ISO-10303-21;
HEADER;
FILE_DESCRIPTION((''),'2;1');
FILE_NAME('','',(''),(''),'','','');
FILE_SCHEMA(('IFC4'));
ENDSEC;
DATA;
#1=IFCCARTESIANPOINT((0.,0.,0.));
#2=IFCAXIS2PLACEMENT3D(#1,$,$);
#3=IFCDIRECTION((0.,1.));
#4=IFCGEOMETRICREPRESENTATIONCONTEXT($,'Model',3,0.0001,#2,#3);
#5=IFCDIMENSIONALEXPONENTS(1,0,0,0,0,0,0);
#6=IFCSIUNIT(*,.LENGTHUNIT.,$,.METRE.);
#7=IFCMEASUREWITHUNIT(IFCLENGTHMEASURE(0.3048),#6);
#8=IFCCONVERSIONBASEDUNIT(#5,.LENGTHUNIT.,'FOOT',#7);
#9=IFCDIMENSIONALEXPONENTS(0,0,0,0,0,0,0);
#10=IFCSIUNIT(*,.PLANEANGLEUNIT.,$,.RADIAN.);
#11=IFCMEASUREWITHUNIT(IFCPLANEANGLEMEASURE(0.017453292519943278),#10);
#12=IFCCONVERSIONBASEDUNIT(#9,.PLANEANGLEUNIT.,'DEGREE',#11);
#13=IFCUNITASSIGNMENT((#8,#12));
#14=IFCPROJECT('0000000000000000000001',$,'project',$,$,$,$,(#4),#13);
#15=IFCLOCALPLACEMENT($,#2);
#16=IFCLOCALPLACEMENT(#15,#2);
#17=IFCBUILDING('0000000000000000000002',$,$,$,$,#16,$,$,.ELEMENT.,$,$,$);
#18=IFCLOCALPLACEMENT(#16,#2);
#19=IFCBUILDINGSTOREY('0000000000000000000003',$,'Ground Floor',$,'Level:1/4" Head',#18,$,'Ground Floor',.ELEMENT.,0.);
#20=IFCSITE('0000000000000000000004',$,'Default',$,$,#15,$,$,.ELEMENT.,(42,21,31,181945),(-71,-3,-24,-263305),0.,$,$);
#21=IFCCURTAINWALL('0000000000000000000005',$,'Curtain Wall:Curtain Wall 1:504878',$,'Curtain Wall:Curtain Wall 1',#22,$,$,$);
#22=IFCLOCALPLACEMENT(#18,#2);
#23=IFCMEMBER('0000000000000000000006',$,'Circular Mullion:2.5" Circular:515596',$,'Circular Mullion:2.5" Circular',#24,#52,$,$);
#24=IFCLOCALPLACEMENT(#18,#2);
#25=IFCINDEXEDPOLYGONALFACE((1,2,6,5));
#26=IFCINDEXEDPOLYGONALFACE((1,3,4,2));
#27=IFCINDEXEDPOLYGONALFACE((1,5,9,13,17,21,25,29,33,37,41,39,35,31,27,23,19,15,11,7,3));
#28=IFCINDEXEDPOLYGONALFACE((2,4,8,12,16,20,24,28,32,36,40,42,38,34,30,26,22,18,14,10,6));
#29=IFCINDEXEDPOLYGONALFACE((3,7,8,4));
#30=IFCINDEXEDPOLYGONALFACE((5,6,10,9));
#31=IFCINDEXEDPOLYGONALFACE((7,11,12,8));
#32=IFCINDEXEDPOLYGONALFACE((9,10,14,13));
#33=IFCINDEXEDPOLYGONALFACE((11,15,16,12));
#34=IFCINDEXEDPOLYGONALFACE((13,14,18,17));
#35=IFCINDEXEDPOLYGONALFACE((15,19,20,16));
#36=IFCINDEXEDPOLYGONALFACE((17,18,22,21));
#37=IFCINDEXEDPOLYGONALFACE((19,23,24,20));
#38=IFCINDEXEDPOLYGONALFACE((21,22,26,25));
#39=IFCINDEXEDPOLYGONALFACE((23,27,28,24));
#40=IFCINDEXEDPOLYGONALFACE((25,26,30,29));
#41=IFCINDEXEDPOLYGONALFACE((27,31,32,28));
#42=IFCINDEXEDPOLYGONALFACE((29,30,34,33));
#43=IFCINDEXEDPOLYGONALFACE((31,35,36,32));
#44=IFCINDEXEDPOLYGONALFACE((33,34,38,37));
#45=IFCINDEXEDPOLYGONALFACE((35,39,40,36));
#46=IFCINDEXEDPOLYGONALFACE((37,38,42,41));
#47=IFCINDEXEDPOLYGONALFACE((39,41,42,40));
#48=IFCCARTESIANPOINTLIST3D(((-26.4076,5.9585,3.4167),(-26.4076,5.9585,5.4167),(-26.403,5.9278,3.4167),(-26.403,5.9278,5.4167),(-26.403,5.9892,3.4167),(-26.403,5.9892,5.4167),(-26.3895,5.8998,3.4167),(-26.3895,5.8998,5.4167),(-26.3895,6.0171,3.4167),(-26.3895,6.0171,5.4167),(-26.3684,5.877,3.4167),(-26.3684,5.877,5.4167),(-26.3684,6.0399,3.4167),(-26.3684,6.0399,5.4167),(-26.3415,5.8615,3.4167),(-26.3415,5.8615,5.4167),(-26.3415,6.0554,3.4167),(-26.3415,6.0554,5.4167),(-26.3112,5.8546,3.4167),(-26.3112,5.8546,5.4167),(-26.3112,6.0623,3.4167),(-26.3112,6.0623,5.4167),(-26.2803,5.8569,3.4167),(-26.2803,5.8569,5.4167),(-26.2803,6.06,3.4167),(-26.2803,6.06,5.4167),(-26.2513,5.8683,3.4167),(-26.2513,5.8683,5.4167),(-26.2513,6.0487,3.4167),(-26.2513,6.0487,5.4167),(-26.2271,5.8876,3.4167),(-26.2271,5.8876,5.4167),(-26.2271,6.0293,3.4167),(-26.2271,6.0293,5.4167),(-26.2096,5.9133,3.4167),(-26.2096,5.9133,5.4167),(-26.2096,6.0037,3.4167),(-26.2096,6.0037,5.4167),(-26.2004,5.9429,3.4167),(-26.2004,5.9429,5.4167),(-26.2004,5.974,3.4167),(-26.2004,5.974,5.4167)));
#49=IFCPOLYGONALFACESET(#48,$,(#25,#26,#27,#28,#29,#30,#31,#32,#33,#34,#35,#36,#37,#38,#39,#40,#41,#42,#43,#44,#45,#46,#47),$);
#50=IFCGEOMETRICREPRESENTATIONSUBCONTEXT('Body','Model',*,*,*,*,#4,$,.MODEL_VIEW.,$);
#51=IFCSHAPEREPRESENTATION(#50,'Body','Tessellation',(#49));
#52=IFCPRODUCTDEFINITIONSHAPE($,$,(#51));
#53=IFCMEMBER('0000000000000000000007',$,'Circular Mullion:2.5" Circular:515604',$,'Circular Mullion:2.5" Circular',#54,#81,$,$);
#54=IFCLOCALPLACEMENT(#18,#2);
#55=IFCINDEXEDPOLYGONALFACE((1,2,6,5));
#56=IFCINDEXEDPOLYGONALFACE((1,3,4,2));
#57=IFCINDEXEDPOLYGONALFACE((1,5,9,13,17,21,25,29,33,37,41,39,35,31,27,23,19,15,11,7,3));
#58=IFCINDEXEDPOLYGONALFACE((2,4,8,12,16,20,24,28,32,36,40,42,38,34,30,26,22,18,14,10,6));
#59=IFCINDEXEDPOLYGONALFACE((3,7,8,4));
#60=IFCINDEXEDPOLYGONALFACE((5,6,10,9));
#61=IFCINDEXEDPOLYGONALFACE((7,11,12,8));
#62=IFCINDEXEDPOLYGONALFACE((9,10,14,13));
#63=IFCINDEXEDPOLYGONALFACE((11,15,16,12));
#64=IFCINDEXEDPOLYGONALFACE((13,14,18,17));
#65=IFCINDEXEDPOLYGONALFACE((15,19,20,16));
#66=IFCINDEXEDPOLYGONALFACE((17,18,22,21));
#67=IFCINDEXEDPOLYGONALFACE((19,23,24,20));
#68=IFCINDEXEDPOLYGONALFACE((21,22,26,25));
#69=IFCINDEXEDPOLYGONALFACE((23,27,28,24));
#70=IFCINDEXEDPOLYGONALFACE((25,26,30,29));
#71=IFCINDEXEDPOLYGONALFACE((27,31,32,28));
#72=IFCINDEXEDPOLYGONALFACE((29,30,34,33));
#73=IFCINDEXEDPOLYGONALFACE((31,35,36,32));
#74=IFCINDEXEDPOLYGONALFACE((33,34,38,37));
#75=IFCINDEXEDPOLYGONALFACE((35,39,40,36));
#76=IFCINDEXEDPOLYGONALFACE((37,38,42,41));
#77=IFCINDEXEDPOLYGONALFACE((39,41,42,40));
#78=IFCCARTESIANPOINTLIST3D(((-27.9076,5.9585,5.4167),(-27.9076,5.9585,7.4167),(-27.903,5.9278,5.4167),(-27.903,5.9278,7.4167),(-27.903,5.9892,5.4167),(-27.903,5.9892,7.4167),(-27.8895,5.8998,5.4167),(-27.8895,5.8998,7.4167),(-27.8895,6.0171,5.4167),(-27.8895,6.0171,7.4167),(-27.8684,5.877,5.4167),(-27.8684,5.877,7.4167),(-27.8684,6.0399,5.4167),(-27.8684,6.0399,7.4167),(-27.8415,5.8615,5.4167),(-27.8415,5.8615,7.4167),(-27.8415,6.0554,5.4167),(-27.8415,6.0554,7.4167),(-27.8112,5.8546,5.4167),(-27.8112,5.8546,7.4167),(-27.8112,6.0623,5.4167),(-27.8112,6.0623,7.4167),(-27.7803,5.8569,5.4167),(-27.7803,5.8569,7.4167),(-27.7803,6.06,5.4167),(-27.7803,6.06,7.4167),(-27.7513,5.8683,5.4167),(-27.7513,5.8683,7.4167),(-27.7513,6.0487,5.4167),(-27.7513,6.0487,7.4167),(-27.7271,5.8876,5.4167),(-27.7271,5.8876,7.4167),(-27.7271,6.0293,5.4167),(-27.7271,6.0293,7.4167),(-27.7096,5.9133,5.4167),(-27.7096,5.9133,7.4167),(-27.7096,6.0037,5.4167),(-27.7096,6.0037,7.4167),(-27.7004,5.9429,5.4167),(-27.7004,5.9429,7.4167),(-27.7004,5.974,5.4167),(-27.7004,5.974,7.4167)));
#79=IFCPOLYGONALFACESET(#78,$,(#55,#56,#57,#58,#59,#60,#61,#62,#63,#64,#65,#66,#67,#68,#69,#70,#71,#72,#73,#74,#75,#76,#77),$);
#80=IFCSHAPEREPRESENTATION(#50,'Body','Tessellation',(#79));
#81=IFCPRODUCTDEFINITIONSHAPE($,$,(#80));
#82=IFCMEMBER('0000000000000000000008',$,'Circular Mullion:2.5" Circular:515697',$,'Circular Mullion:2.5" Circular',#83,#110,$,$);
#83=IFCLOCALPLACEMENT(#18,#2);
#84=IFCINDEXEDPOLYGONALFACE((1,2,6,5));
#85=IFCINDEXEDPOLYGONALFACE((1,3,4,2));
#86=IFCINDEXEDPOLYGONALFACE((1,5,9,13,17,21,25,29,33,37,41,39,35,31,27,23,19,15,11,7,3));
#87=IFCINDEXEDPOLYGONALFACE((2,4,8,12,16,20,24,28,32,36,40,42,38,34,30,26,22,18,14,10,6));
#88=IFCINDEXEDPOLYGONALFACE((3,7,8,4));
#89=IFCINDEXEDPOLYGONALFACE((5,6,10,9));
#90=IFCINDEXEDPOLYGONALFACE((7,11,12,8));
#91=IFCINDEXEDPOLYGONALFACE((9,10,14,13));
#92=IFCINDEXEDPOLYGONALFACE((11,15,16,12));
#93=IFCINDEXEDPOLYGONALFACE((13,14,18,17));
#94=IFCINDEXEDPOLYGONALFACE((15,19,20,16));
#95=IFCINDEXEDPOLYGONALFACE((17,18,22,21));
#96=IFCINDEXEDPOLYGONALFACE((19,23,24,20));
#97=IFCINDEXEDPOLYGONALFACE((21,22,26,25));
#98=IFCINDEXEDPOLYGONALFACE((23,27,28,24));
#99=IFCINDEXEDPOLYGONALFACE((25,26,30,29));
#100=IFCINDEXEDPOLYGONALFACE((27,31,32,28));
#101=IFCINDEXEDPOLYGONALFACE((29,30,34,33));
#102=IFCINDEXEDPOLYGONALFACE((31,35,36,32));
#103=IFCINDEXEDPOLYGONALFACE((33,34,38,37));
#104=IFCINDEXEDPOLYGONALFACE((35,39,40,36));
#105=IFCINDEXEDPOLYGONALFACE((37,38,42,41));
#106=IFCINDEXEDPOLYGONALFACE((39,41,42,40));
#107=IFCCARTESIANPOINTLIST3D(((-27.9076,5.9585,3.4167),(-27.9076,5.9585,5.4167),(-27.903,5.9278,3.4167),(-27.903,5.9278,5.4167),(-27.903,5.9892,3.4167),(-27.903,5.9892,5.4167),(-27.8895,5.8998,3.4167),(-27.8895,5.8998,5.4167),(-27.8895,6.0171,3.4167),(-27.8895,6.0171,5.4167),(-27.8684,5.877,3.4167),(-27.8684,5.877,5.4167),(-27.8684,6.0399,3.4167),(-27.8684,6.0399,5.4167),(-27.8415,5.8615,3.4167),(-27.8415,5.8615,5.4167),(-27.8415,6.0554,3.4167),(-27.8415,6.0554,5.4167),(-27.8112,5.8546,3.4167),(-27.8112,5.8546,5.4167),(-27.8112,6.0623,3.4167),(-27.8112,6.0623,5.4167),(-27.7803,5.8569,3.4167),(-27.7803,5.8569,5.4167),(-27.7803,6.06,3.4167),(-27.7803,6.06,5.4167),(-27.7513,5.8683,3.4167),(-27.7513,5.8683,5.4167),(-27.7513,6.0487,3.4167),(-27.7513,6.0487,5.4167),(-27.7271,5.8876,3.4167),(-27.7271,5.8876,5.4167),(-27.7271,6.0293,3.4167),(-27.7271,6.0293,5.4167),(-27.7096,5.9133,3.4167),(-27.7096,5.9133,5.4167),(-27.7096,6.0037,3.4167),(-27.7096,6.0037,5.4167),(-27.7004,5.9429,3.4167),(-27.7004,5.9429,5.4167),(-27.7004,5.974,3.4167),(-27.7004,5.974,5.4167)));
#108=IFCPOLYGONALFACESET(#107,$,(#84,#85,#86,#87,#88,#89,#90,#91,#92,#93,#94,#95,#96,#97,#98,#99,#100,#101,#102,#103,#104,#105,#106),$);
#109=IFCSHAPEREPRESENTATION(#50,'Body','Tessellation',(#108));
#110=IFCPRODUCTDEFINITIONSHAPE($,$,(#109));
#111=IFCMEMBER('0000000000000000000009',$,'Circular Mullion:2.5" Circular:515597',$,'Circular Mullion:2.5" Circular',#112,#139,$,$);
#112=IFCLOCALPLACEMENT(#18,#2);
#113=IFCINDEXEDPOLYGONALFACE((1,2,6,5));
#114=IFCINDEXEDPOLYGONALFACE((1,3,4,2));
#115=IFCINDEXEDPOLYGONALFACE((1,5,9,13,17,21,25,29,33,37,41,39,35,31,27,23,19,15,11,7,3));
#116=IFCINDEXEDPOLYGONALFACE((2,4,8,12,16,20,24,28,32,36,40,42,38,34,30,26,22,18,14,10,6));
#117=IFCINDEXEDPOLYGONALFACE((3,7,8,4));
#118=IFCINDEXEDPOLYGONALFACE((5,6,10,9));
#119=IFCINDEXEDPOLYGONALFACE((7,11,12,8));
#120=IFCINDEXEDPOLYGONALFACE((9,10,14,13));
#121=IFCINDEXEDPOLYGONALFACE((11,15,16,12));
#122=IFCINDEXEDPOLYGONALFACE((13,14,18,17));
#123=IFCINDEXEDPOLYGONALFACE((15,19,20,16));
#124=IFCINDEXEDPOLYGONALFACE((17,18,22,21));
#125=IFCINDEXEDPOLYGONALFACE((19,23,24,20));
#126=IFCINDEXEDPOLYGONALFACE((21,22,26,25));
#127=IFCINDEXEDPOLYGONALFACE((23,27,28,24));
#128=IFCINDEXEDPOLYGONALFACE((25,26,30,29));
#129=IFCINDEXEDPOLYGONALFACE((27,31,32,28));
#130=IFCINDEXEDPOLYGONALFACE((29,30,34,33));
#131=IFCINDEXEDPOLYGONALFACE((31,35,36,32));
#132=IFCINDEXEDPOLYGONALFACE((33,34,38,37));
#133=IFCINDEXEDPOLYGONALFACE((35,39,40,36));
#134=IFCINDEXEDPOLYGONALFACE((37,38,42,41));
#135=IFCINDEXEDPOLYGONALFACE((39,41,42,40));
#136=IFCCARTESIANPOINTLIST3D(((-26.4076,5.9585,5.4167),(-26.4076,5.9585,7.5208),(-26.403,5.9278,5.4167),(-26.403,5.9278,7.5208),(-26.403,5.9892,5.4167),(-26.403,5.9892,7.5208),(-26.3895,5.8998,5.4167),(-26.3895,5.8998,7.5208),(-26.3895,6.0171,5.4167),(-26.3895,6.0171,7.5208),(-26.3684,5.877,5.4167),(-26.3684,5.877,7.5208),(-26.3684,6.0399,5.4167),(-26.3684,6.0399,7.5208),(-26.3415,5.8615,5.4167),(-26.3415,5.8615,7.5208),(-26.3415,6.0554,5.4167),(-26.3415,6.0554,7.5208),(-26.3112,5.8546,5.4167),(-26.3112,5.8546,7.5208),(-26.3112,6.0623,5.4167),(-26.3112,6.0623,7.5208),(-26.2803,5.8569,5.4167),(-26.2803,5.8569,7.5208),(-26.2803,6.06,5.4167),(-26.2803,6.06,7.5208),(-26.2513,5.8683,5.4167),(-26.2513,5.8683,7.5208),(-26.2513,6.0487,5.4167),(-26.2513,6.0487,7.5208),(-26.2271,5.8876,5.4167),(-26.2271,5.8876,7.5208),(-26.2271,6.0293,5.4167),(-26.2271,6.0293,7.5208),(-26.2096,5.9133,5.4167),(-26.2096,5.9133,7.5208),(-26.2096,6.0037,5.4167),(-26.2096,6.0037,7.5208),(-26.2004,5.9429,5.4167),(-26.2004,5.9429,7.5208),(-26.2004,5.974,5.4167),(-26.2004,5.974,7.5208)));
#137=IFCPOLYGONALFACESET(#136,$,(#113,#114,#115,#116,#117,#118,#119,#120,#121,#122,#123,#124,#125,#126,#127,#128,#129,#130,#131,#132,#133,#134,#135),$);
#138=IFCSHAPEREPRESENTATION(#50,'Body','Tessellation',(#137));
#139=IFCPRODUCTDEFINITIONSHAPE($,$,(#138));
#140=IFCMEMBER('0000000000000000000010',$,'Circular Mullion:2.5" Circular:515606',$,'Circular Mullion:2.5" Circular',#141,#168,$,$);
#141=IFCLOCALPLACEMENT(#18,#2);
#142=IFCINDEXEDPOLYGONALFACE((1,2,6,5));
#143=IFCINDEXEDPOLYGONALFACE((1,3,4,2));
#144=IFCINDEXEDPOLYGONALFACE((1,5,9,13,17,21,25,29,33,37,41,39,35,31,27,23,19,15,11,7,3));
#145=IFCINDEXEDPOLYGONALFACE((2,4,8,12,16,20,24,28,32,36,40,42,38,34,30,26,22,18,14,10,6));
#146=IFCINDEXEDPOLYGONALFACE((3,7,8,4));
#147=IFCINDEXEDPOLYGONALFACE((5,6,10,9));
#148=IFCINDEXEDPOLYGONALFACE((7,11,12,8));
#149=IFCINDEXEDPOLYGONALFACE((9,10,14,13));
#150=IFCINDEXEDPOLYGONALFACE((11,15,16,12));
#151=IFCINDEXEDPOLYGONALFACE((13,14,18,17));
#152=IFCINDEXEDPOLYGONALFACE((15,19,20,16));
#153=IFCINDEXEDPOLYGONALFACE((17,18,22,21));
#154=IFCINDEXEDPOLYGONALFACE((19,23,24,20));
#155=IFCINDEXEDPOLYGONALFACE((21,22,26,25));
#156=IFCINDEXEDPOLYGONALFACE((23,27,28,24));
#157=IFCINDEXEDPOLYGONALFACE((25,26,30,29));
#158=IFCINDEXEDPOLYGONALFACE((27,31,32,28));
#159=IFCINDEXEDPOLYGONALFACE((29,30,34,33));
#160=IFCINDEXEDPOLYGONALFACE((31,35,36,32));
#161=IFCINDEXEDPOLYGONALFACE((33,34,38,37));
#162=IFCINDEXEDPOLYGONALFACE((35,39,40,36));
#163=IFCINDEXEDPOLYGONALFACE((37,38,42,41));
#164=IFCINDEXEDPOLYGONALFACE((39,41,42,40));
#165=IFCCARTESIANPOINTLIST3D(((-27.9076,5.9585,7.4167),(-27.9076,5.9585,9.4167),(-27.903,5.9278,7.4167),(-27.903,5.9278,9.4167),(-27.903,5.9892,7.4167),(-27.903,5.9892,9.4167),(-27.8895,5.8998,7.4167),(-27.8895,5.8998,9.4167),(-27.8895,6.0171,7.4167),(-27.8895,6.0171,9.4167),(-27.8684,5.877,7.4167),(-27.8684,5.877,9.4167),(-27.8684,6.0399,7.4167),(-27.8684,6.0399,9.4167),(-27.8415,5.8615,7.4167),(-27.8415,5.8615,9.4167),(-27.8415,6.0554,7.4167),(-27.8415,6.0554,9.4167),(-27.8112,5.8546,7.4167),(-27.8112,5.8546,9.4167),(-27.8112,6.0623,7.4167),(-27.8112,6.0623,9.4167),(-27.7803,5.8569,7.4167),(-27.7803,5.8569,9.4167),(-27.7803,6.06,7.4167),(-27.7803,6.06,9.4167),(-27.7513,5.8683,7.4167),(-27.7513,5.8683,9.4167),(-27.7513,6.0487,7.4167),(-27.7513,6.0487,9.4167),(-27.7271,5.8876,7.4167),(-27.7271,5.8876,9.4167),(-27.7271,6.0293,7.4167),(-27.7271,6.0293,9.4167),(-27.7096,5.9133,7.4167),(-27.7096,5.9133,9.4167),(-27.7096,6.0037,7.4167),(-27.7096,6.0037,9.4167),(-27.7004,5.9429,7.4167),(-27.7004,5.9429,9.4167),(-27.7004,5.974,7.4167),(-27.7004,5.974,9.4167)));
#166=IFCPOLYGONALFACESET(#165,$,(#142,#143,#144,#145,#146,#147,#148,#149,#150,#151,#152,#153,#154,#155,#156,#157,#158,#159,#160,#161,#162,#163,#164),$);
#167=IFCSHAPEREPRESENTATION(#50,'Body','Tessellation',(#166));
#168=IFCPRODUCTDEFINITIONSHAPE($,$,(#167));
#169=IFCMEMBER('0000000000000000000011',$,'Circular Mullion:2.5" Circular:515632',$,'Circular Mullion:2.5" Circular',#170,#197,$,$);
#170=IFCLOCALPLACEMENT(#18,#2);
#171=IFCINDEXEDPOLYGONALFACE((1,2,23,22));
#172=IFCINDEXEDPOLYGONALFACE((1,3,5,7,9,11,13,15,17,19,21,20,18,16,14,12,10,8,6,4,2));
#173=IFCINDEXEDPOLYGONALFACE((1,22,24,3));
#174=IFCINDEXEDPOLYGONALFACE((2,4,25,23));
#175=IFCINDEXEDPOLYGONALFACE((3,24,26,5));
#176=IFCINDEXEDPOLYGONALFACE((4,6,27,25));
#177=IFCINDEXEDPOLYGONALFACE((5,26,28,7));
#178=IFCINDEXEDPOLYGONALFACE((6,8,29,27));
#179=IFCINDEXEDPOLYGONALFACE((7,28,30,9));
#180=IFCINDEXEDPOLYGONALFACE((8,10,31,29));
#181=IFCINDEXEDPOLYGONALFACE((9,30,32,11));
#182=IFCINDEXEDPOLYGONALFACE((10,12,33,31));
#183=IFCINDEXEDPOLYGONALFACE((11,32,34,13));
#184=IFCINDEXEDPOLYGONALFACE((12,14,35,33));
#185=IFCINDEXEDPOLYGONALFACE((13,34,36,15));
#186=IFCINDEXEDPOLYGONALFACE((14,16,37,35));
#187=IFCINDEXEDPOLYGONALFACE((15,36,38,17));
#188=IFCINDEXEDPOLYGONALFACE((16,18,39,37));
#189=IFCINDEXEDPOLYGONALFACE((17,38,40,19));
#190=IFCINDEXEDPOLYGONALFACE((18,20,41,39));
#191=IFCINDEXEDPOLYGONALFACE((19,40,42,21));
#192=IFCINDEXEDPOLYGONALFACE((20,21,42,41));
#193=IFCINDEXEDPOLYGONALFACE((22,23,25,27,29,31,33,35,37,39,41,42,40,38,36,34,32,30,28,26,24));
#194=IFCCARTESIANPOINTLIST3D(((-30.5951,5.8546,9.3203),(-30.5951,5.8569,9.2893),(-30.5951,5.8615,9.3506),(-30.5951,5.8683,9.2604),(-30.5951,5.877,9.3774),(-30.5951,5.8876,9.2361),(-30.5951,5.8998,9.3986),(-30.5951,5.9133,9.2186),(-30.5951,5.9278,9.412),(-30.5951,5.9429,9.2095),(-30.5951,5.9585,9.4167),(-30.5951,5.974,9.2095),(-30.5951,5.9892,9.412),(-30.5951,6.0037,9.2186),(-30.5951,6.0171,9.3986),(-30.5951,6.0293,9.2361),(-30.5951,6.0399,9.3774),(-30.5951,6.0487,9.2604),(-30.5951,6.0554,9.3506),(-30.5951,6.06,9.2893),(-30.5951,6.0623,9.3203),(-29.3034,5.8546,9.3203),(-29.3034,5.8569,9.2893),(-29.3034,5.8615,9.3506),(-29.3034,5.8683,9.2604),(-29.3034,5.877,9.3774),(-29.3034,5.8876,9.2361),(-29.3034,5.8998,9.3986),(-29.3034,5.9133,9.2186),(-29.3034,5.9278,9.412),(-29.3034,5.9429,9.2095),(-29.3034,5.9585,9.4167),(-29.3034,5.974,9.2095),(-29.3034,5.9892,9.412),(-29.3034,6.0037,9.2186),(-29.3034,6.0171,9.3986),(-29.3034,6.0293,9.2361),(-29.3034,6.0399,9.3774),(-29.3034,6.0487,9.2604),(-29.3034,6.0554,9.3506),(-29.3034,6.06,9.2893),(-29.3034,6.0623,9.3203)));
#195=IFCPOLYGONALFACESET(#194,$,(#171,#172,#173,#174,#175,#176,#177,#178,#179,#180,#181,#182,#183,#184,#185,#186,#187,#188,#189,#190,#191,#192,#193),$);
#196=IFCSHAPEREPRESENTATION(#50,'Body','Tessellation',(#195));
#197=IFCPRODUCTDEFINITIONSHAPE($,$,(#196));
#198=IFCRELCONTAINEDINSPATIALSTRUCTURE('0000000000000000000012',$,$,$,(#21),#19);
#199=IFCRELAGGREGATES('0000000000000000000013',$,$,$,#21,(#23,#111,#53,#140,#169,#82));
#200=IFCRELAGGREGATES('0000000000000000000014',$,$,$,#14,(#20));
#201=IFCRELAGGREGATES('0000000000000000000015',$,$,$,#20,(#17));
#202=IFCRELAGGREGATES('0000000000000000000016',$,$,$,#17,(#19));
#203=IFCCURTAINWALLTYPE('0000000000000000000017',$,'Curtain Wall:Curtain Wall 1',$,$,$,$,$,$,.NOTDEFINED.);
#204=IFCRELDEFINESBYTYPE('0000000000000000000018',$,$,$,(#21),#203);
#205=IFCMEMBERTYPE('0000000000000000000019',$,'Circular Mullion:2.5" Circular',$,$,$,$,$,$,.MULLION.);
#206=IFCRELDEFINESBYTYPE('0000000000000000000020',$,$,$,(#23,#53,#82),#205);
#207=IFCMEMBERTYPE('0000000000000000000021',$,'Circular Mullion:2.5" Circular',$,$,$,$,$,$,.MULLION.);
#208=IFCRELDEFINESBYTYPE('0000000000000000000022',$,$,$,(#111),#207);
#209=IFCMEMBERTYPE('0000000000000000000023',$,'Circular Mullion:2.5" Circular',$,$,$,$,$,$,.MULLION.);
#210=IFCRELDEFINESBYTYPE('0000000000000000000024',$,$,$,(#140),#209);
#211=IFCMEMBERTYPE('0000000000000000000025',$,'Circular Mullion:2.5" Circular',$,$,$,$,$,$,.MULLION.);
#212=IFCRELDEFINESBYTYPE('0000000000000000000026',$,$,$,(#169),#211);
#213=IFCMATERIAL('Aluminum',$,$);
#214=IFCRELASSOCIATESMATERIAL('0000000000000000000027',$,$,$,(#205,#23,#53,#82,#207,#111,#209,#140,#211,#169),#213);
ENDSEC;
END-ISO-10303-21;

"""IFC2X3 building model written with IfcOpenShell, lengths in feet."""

from ifc_helpers import new_model, entity, si_unit, converted_unit, direction, frame, frame_2d, origin, place, context, subcontext, project, spatial, circle, extrude, source, transform, mapped, material, type_object, type_shapes, element, aggregate, save


model = new_model("IFC2X3")

# Units and contexts
model_context = context("Model", 3, precision=0.0001, world=origin(), true_north=direction((0.0, 1.0)))
body_context = subcontext(model_context, "Body", "Model", "MODEL_VIEW")
ifc_project = project(units=[converted_unit("LENGTHUNIT", "FOOT", entity("IfcLengthMeasure", 0.3048), si_unit("LENGTHUNIT", "METRE"), dimensions=[1, 0, 0, 0, 0, 0, 0]), converted_unit("PLANEANGLEUNIT", "DEGREE", entity("IfcPlaneAngleMeasure", 0.017453292519943278), si_unit("PLANEANGLEUNIT", "RADIAN"), dimensions=[0, 0, 0, 0, 0, 0, 0])], contexts=[model_context])

# Site, building, storey
site_placement = place(None, origin())
site = spatial("IfcSite", under=ifc_project, at=site_placement, Name="Default", CompositionType="ELEMENT", RefLatitude=(42, 21, 31, 181945), RefLongitude=(-71, -3, -24, -263305), RefElevation=0.0)
building_placement = place(site_placement, origin())
building = spatial("IfcBuilding", under=site, at=building_placement, CompositionType="ELEMENT")
storey_placement = place(building_placement, origin())
storey = spatial("IfcBuildingStorey", under=building, at=storey_placement, Name="Ground Floor", ObjectType="Level:1/4\" Head", LongName="Ground Floor", CompositionType="ELEMENT", Elevation=0.0)

# Curtain wall, members
curtain_wall_type = type_object("IfcCurtainWallType", Name="Curtain Wall:Curtain Wall 1", PredefinedType="NOTDEFINED")
curtain_wall_placement = place(storey_placement, origin())
curtain_wall = element("IfcCurtainWall", 1, at=curtain_wall_placement, inside=storey, type_object=curtain_wall_type, Name="Curtain Wall:Curtain Wall 1:504878", ObjectType="Curtain Wall:Curtain Wall 1")
ifc_material_1 = material(Name="Aluminum")
member_type_1 = type_object("IfcMemberType", Name="Circular Mullion:2.5\" Circular", PredefinedType="MULLION", material=ifc_material_1)
shared_shape_1 = source(origin(), body_context, "Body", "SweptSolid", [
    extrude(circle(Radius=0.1042, at=frame_2d((0.0, 0.0), x_axis=(1.0, 0.0))), frame((0.0, 0.0, -2.0)), (0.0, 0.0, 1.0), 2.0),
])
type_shapes(member_type_1, [shared_shape_1])
member_1_placement = place(curtain_wall_placement, frame((-26.3034, 5.9585, 3.4167), z_axis=(0.0, 0.0, -1.0), x_axis=(-1.0, 0.0, 0.0)))
member_1 = element("IfcMember", 2, at=member_1_placement, type_object=member_type_1, material=ifc_material_1, Name="Circular Mullion:2.5\" Circular:515596", ObjectType="Circular Mullion:2.5\" Circular", context=body_context, shape_type="MappedRepresentation", body=[
    mapped(shared_shape_1, transform((0.0, 0.0, 0.0), scale=1.0)),
])
member_2_placement = place(curtain_wall_placement, frame((-27.8034, 5.9585, 5.4167), z_axis=(0.0, 0.0, -1.0), x_axis=(-1.0, 0.0, 0.0)))
member_2 = element("IfcMember", 3, at=member_2_placement, type_object=member_type_1, material=ifc_material_1, Name="Circular Mullion:2.5\" Circular:515604", ObjectType="Circular Mullion:2.5\" Circular", context=body_context, shape_type="MappedRepresentation", body=[
    mapped(shared_shape_1, transform((0.0, 0.0, 0.0), scale=1.0)),
])
member_3_placement = place(curtain_wall_placement, frame((-27.8034, 5.9585, 3.4167), z_axis=(0.0, 0.0, -1.0), x_axis=(-1.0, 0.0, 0.0)))
member_3 = element("IfcMember", 4, at=member_3_placement, type_object=member_type_1, material=ifc_material_1, Name="Circular Mullion:2.5\" Circular:515697", ObjectType="Circular Mullion:2.5\" Circular", context=body_context, shape_type="MappedRepresentation", body=[
    mapped(shared_shape_1, transform((0.0, 0.0, 0.0), scale=1.0)),
])
member_type_2 = type_object("IfcMemberType", Name="Circular Mullion:2.5\" Circular", PredefinedType="MULLION", material=ifc_material_1)
shared_shape_2 = source(origin(), body_context, "Body", "SweptSolid", [
    extrude(circle(Radius=0.1042, at=frame_2d((0.0, 0.0), x_axis=(1.0, 0.0))), frame((0.0, 0.0, -2.1042)), (0.0, 0.0, 1.0), 2.1042),
])
type_shapes(member_type_2, [shared_shape_2])
member_4_placement = place(curtain_wall_placement, frame((-26.3034, 5.9585, 5.4167), z_axis=(0.0, 0.0, -1.0), x_axis=(-1.0, 0.0, 0.0)))
member_4 = element("IfcMember", 5, at=member_4_placement, type_object=member_type_2, material=ifc_material_1, Name="Circular Mullion:2.5\" Circular:515597", ObjectType="Circular Mullion:2.5\" Circular", context=body_context, shape_type="MappedRepresentation", body=[
    mapped(shared_shape_2, transform((0.0, 0.0, 0.0), scale=1.0)),
])
member_type_3 = type_object("IfcMemberType", Name="Circular Mullion:2.5\" Circular", PredefinedType="MULLION", material=ifc_material_1)
shared_shape_3 = source(origin(), body_context, "Body", "SweptSolid", [
    extrude(circle(Radius=0.1042, at=frame_2d((0.0, 0.0), x_axis=(1.0, 0.0))), frame((0.0, 0.0, -2.0)), (0.0, 0.0, 1.0), 2.0),
])
type_shapes(member_type_3, [shared_shape_3])
member_5_placement = place(curtain_wall_placement, frame((-27.8034, 5.9585, 7.4167), z_axis=(0.0, 0.0, -1.0), x_axis=(-1.0, 0.0, 0.0)))
member_5 = element("IfcMember", 6, at=member_5_placement, type_object=member_type_3, material=ifc_material_1, Name="Circular Mullion:2.5\" Circular:515606", ObjectType="Circular Mullion:2.5\" Circular", context=body_context, shape_type="MappedRepresentation", body=[
    mapped(shared_shape_3, transform((0.0, 0.0, 0.0), scale=1.0)),
])
member_type_4 = type_object("IfcMemberType", Name="Circular Mullion:2.5\" Circular", PredefinedType="MULLION", material=ifc_material_1)
shared_shape_4 = source(origin(), body_context, "Body", "SweptSolid", [
    extrude(circle(Radius=0.1042, at=frame_2d((0.0, 0.0), x_axis=(1.0, 0.0))), frame((-0.1042, 0.0, -1.2917)), (0.0, 0.0, 1.0), 1.2917),
])
type_shapes(member_type_4, [shared_shape_4])
member_6_placement = place(curtain_wall_placement, frame((-30.5951, 5.9585, 9.4167), z_axis=(-1.0, 0.0, 0.0), x_axis=(0.0, 0.0, 1.0)))
member_6 = element("IfcMember", 7, at=member_6_placement, type_object=member_type_4, material=ifc_material_1, Name="Circular Mullion:2.5\" Circular:515632", ObjectType="Circular Mullion:2.5\" Circular", context=body_context, shape_type="MappedRepresentation", body=[
    mapped(shared_shape_4, transform((0.0, 0.0, 0.0), scale=1.0)),
])
aggregate(curtain_wall, [member_1, member_4, member_2, member_5, member_6, member_3])

save(model, "model.ifc")
